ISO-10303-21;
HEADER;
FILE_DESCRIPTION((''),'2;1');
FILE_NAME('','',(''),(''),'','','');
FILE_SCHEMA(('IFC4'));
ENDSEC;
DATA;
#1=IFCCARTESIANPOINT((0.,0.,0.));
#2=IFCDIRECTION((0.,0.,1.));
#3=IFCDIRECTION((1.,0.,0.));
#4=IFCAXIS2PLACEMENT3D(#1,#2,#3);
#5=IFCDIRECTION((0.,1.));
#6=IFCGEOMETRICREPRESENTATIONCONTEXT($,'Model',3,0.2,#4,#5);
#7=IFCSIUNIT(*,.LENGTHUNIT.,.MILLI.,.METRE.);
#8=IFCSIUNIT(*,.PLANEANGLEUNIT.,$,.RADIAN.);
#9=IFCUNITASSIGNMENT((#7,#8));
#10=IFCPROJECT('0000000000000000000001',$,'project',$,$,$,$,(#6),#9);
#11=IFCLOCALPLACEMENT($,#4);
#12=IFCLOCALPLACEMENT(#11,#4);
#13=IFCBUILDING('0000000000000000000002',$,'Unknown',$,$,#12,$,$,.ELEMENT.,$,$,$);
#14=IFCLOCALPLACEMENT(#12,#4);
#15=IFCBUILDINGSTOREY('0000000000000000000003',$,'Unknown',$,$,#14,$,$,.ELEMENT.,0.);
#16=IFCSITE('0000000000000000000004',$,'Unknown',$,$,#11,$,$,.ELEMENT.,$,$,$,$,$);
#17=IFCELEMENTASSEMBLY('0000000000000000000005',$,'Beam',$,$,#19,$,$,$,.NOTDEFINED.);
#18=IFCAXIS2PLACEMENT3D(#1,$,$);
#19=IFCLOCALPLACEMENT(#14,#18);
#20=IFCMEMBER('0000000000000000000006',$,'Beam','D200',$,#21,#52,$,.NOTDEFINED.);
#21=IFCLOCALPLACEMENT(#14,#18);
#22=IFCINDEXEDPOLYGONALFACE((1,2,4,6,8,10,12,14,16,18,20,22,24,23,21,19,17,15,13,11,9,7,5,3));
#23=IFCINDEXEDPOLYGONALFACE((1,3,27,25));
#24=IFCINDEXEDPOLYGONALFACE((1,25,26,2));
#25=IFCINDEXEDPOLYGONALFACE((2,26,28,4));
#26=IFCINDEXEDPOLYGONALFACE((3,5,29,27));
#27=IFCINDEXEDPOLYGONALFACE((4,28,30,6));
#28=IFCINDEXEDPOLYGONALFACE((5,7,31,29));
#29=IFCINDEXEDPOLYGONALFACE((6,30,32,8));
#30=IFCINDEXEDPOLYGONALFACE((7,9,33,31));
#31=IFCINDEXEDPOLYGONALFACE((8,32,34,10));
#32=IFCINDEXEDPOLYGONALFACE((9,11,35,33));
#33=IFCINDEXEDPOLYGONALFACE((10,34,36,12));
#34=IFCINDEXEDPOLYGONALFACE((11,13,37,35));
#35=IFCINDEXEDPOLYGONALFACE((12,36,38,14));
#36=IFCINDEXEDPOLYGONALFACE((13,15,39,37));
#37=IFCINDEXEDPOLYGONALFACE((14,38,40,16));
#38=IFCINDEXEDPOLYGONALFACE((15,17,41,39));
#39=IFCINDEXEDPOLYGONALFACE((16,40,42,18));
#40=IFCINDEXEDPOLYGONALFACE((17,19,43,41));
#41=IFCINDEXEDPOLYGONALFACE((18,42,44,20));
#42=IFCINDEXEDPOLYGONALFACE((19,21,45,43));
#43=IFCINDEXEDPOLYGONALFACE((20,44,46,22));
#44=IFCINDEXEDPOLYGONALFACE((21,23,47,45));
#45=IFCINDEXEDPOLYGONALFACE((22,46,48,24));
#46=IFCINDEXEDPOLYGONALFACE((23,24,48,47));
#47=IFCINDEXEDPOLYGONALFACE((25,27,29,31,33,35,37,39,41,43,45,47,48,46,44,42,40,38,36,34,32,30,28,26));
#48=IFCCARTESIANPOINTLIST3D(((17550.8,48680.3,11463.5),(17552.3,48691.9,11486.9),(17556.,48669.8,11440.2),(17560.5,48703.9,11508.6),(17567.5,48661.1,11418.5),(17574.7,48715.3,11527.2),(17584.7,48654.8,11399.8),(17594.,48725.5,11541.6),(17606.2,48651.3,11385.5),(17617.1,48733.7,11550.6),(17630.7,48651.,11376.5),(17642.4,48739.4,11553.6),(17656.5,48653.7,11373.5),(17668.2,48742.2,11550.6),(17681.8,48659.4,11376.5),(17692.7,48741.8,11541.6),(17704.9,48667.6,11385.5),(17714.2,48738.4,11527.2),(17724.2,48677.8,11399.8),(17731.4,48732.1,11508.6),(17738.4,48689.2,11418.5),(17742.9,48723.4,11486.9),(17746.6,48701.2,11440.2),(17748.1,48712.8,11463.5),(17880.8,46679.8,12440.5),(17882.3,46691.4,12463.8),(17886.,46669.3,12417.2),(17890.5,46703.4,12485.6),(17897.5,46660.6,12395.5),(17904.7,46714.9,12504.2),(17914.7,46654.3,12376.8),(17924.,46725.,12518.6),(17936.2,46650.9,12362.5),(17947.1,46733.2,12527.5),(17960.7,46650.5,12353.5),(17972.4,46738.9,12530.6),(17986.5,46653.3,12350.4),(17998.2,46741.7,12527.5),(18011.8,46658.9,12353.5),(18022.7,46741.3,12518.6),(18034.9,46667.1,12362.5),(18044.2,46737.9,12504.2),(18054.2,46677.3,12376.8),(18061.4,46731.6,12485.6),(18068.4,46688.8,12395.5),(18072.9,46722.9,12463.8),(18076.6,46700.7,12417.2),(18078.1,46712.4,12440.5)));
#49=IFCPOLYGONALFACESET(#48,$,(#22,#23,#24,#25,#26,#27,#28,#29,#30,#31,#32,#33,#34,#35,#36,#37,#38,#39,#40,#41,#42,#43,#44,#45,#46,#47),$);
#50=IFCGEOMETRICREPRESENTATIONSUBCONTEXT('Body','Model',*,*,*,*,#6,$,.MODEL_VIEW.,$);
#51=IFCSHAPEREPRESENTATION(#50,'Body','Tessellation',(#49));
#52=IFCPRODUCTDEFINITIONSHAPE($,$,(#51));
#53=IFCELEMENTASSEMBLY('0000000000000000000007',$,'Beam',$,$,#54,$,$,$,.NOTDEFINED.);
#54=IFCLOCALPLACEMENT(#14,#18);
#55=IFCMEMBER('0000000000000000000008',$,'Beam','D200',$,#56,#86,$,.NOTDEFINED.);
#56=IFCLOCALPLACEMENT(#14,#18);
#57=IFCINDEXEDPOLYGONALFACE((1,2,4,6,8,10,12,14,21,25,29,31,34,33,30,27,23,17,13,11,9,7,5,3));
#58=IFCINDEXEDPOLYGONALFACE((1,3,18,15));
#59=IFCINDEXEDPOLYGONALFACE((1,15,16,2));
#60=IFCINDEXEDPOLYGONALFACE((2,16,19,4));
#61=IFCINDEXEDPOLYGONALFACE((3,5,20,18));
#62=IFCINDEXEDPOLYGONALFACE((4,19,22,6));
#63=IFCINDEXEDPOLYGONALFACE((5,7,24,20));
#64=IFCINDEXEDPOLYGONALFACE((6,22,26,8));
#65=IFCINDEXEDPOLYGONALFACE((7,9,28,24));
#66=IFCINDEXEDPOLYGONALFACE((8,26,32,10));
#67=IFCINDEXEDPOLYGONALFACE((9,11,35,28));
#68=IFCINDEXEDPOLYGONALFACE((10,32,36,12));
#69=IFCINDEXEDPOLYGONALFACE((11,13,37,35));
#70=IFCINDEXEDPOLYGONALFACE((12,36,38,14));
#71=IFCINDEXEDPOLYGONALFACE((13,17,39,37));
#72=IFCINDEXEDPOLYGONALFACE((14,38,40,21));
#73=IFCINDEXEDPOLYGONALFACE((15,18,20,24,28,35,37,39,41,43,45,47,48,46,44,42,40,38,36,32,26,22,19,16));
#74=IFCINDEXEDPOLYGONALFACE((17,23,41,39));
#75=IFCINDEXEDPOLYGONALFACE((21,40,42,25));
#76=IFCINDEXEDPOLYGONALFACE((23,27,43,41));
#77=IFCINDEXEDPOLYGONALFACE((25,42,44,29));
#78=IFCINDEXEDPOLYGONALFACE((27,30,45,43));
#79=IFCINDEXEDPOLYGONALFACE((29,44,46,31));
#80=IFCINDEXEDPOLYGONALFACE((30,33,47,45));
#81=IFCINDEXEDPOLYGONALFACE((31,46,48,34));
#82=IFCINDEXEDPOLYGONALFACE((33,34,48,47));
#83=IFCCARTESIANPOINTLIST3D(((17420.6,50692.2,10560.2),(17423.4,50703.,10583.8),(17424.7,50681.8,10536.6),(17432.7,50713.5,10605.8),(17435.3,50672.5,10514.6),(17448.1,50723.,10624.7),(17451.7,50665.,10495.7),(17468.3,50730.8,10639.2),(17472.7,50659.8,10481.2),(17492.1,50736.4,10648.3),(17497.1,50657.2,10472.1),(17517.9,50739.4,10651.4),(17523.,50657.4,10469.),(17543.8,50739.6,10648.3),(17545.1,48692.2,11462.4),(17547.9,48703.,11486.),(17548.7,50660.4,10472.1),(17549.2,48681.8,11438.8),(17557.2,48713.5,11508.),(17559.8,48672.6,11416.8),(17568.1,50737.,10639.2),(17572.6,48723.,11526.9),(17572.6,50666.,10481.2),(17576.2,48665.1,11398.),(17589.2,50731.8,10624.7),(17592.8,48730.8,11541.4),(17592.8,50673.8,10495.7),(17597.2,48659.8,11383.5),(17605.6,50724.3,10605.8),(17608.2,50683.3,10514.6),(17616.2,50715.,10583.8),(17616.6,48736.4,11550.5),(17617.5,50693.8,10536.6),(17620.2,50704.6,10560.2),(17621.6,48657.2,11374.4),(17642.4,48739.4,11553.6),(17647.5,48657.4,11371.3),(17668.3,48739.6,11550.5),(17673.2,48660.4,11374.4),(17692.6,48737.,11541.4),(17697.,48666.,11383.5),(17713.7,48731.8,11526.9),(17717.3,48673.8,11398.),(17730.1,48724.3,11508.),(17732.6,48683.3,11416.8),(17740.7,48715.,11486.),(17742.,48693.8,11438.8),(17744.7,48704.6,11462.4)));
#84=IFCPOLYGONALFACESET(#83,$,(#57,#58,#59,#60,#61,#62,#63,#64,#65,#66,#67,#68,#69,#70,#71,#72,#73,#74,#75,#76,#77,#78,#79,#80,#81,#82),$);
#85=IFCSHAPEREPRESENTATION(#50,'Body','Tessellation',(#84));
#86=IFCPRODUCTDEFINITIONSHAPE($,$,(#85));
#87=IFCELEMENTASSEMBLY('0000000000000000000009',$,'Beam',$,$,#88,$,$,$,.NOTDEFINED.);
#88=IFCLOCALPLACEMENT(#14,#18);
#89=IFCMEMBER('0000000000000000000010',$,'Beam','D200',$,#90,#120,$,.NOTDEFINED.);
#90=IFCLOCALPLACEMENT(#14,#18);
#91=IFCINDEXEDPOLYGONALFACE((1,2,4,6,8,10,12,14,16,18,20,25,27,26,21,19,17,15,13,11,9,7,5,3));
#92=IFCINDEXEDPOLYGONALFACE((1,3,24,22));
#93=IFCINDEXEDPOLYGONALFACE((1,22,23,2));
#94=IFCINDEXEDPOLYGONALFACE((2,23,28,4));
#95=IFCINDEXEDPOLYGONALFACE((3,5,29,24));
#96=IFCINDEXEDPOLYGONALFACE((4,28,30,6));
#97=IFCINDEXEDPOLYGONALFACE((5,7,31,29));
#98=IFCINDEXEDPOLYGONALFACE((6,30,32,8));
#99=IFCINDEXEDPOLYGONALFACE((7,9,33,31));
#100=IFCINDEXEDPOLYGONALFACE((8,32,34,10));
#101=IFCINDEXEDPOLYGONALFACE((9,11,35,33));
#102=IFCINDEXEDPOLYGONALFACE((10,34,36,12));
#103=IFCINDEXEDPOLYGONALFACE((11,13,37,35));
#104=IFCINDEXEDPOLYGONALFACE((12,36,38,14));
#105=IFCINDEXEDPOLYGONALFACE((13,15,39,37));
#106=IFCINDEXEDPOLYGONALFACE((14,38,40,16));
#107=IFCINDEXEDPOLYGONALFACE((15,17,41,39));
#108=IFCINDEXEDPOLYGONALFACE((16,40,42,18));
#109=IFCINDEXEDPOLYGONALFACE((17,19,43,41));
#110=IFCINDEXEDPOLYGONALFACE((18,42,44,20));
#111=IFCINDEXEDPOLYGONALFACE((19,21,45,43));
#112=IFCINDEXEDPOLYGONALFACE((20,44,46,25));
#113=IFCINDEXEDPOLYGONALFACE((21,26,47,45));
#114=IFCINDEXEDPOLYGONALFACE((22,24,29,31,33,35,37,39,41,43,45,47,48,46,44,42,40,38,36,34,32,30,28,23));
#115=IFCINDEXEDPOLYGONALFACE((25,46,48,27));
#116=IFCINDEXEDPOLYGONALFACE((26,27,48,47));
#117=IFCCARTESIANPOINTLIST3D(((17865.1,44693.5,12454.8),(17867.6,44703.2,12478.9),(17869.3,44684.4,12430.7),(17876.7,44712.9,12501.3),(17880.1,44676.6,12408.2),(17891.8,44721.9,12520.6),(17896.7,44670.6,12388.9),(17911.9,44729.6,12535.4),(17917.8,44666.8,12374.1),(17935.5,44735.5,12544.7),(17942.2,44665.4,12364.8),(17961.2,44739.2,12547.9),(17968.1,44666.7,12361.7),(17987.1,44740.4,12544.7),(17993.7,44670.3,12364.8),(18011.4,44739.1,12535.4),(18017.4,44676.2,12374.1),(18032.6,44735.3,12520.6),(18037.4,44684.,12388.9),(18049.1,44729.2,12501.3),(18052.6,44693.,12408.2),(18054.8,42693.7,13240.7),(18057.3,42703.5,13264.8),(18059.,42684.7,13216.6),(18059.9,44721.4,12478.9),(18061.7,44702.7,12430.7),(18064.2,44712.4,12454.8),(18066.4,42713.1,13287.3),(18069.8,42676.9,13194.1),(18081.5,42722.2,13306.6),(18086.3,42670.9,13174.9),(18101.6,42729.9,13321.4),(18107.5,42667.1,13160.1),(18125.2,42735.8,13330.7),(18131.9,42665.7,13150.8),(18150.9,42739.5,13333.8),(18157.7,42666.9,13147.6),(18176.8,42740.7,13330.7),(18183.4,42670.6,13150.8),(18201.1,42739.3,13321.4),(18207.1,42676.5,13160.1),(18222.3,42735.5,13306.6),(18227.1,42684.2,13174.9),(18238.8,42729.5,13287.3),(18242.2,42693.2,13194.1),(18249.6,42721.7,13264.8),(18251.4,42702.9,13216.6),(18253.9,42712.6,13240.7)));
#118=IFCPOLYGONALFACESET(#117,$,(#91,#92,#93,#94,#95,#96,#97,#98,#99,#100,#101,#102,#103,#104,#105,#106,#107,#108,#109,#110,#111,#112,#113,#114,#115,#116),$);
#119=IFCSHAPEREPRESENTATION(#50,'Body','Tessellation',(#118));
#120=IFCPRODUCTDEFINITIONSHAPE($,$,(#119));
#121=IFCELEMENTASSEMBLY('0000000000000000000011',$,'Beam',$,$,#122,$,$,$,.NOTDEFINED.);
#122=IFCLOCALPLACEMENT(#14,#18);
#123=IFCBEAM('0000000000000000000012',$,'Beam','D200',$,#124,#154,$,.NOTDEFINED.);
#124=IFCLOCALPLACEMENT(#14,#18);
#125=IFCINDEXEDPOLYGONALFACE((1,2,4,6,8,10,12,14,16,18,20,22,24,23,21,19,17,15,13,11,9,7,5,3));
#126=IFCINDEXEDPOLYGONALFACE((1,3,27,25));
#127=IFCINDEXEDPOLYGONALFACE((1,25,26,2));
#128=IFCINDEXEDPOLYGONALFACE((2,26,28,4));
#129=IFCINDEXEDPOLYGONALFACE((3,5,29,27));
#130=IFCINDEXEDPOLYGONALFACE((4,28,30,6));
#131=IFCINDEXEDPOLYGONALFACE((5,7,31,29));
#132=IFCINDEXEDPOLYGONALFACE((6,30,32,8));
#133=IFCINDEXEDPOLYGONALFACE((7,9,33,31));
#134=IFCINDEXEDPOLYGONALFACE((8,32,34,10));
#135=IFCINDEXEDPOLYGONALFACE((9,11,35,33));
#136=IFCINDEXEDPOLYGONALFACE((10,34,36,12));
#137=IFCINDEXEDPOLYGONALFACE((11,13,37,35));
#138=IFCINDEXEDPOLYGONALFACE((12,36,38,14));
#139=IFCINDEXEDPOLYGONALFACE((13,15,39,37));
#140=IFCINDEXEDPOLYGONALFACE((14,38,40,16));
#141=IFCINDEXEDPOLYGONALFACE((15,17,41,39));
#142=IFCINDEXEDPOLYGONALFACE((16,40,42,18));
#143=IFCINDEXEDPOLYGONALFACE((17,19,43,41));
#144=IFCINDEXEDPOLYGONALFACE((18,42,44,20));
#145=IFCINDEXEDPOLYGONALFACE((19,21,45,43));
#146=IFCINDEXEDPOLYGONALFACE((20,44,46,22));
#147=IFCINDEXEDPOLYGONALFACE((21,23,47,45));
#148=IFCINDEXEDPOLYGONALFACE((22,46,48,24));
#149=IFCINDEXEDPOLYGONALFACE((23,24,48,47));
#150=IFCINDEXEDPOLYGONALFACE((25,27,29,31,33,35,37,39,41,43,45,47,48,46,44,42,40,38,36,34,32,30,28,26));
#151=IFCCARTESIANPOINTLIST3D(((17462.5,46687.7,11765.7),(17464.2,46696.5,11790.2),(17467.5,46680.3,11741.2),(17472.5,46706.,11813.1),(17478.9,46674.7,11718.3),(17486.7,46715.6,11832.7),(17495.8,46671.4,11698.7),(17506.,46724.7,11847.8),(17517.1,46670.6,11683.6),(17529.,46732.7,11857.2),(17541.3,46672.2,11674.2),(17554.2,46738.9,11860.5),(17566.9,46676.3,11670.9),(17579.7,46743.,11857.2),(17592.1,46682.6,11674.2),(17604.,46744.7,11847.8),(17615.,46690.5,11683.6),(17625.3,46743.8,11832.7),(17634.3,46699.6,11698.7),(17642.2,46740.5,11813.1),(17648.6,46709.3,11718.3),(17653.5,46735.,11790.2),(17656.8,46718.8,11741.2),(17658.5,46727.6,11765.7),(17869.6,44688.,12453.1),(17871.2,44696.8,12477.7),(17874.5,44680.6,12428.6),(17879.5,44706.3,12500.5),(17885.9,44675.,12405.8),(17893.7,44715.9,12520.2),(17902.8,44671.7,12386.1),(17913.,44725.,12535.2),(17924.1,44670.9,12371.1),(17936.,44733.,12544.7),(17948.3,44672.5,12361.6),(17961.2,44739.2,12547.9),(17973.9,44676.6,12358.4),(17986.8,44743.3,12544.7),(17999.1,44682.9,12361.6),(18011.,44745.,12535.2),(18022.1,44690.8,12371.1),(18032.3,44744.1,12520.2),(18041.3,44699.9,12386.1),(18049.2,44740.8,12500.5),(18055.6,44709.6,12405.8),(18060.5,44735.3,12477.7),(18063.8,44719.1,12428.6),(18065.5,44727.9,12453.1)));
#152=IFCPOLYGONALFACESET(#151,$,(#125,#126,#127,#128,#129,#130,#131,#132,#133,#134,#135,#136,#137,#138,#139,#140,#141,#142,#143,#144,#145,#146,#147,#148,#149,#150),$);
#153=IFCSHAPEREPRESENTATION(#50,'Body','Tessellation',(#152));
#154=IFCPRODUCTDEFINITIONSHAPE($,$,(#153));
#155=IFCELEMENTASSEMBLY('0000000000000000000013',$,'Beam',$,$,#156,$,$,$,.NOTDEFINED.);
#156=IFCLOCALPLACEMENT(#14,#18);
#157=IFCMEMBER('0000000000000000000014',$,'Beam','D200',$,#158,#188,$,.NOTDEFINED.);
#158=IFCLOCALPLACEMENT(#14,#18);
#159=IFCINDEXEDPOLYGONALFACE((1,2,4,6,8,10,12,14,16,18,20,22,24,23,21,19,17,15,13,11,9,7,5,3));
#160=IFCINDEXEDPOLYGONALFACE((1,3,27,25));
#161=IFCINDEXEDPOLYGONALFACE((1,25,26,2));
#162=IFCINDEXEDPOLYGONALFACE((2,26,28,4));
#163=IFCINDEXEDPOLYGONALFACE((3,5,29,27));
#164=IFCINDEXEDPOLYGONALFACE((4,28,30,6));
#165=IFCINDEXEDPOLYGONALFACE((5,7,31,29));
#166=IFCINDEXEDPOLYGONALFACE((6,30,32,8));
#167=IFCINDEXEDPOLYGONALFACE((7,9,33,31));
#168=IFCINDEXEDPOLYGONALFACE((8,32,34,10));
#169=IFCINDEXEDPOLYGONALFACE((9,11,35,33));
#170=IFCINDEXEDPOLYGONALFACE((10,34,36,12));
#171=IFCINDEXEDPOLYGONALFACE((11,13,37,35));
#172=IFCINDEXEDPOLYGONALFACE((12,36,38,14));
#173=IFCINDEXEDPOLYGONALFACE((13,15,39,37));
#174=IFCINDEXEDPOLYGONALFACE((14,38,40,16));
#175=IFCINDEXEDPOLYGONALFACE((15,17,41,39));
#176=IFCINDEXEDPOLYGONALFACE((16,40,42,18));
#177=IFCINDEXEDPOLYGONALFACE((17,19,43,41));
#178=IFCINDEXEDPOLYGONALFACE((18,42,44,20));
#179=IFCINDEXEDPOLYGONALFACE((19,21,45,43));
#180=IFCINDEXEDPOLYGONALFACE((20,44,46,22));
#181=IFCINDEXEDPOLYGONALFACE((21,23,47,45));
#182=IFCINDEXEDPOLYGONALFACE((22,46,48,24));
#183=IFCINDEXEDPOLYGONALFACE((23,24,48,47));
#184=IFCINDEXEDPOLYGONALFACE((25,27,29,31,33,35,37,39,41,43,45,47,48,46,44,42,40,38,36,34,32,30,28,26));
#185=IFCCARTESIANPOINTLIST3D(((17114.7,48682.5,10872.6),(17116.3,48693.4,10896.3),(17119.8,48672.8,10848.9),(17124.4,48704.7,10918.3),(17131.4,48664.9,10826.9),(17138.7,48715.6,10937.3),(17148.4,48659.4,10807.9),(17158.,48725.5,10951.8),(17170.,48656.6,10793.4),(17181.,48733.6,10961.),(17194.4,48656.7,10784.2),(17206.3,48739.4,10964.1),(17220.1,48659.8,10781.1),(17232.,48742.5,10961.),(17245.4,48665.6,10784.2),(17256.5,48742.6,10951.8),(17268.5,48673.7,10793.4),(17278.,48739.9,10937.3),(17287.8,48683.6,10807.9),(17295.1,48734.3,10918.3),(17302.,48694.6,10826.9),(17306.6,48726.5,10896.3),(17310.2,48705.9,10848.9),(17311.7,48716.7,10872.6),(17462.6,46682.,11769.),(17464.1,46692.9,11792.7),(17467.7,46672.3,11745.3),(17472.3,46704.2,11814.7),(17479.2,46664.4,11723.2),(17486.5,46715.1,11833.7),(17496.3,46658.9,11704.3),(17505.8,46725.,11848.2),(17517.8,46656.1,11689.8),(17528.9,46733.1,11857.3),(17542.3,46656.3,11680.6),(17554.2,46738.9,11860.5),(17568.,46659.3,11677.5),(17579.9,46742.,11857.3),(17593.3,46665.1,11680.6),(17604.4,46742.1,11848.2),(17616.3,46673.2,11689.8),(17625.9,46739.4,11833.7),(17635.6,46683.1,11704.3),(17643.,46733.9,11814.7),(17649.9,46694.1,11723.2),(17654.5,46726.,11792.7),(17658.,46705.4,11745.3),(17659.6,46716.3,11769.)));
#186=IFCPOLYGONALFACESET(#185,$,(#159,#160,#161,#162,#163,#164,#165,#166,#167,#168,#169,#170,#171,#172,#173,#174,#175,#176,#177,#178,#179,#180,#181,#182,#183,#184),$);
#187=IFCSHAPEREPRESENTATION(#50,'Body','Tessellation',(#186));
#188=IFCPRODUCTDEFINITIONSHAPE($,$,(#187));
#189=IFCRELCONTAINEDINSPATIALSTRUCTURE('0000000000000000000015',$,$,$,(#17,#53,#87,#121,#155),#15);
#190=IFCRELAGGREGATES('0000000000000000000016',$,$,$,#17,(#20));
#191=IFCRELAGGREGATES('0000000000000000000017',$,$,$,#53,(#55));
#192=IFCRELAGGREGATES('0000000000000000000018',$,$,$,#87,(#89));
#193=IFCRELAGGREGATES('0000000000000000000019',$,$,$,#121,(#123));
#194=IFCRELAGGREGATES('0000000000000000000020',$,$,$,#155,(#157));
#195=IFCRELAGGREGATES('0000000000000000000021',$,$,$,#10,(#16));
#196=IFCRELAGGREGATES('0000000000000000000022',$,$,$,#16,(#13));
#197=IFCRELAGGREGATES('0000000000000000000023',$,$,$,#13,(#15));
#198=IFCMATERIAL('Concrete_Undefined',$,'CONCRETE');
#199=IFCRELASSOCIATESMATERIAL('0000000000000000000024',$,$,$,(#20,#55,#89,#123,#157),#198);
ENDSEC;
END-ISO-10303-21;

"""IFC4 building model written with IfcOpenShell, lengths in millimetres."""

from ifc_helpers import new_model, si_unit, direction, frame, origin_with_axes, place, context, subcontext, project, spatial, line, indexed_curve, outline, extrude, material, element, aggregate, save


model = new_model("IFC4")

# Units and contexts
model_context = context("Model", 3, precision=0.2, world=origin_with_axes(), true_north=direction((0.0, 1.0)))
body_context = subcontext(model_context, "Body", "Model", "MODEL_VIEW")
ifc_project = project(units=[si_unit("LENGTHUNIT", "METRE", prefix="MILLI"), si_unit("PLANEANGLEUNIT", "RADIAN")], contexts=[model_context])

# Site, building, storey
site_placement = place(None, origin_with_axes())
site = spatial("IfcSite", under=ifc_project, at=site_placement, Name="Unknown", CompositionType="ELEMENT")
building_placement = place(site_placement, origin_with_axes())
building = spatial("IfcBuilding", under=site, at=building_placement, Name="Unknown", CompositionType="ELEMENT")
storey_placement = place(building_placement, origin_with_axes())
storey = spatial("IfcBuildingStorey", under=building, at=storey_placement, Name="Unknown", CompositionType="ELEMENT", Elevation=0.0)

# Shared definitions
ifc_material = material(Name="Concrete_Undefined", Category="CONCRETE")

# Element assemblies, members
assembly_1_placement = place(storey_placement, frame((17649.4, 48696.6, 11463.5), z_axis=(-0.986666, -0.162758, 0.0), x_axis=(0.146624, -0.888853, 0.434098)))
assembly_1 = element("IfcElementAssembly", 1, at=assembly_1_placement, inside=storey, Name="Beam", PredefinedType="NOTDEFINED")
member_1_placement = place(assembly_1_placement, origin_with_axes())
member_1 = element("IfcMember", 2, at=member_1_placement, material=ifc_material, Name="Beam", Description="D200", PredefinedType="NOTDEFINED", context=body_context, shape_type="SolidModel", body=[
    extrude(outline(indexed_curve([(100.0, 0.0), (96.6, 25.9), (86.6, 50.0), (70.7, 70.7), (50.0, 86.6), (25.9, 96.6), (0.0, 100.0), (-25.9, 96.6), (-50.0, 86.6), (-70.7, 70.7), (-86.6, 50.0), (-96.6, 25.9), (-100.0, 0.0), (-96.6, -25.9), (-86.6, -50.0), (-70.7, -70.7), (-50.0, -86.6), (-25.9, -96.6), (0.0, -100.0), (25.9, -96.6), (50.0, -86.6), (70.7, -70.7), (86.6, -50.0), (96.6, -25.9)], segments=[line(1, 2, 3, 4, 5, 6, 7, 8, 9, 10, 11, 12, 13, 14, 15, 16, 17, 18, 19, 20, 21, 22, 23, 24, 1)])), frame((0.0, 0.0, 0.0), z_axis=(-1.0, 0.0, 0.0), x_axis=(0.0, 0.0, 1.0)), (0.0, 0.0, -1.0), 2250.6),
])
aggregate(assembly_1, [member_1])
assembly_2_placement = place(storey_placement, frame((17520.4, 50698.4, 10560.2), z_axis=(-0.998068, -0.062127, 0.0), x_axis=(0.05665, -0.91007, 0.410564)))
assembly_2 = element("IfcElementAssembly", 3, at=assembly_2_placement, inside=storey, Name="Beam", PredefinedType="NOTDEFINED")
member_2_placement = place(assembly_2_placement, origin_with_axes())
member_2 = element("IfcMember", 4, at=member_2_placement, material=ifc_material, Name="Beam", Description="D200", PredefinedType="NOTDEFINED", context=body_context, shape_type="SolidModel", body=[
    extrude(outline(indexed_curve([(100.0, 0.0), (96.6, 25.9), (86.6, 50.0), (70.7, 70.7), (50.0, 86.6), (25.9, 96.6), (0.0, 100.0), (-25.9, 96.6), (-50.0, 86.6), (-70.7, 70.7), (-86.6, 50.0), (-96.6, 25.9), (-100.0, 0.0), (-96.6, -25.9), (-86.6, -50.0), (-70.7, -70.7), (-50.0, -86.6), (-25.9, -96.6), (0.0, -100.0), (25.9, -96.6), (50.0, -86.6), (70.7, -70.7), (86.6, -50.0), (96.6, -25.9)], segments=[line(1, 2, 3, 4, 5, 6, 7, 8, 9, 10, 11, 12, 13, 14, 15, 16, 17, 18, 19, 20, 21, 22, 23, 24, 1)])), frame((0.0, 0.0, 0.0), z_axis=(-1.0, 0.0, 0.0), x_axis=(0.0, 0.0, 1.0)), (0.0, 0.0, -1.0), 2197.6),
])
aggregate(assembly_2, [member_2])
assembly_3_placement = place(storey_placement, frame((17964.6, 44702.9, 12454.8), z_axis=(-0.995531, -0.094435, 0.0), x_axis=(0.087944, -0.927097, 0.364358)))
assembly_3 = element("IfcElementAssembly", 5, at=assembly_3_placement, inside=storey, Name="Beam", PredefinedType="NOTDEFINED")
member_3_placement = place(assembly_3_placement, origin_with_axes())
member_3 = element("IfcMember", 6, at=member_3_placement, material=ifc_material, Name="Beam", Description="D200", PredefinedType="NOTDEFINED", context=body_context, shape_type="SolidModel", body=[
    extrude(outline(indexed_curve([(100.0, 0.0), (96.6, 25.9), (86.6, 50.0), (70.7, 70.7), (50.0, 86.6), (25.9, 96.6), (0.0, 100.0), (-25.9, 96.6), (-50.0, 86.6), (-70.7, 70.7), (-86.6, 50.0), (-96.6, 25.9), (-100.0, 0.0), (-96.6, -25.9), (-86.6, -50.0), (-70.7, -70.7), (-50.0, -86.6), (-25.9, -96.6), (0.0, -100.0), (25.9, -96.6), (50.0, -86.6), (70.7, -70.7), (86.6, -50.0), (96.6, -25.9)], segments=[line(1, 2, 3, 4, 5, 6, 7, 8, 9, 10, 11, 12, 13, 14, 15, 16, 17, 18, 19, 20, 21, 22, 23, 24, 1)])), frame((0.0, 0.0, 0.0), z_axis=(-1.0, 0.0, 0.0), x_axis=(0.0, 0.0, 1.0)), (0.0, 0.0, -1.0), 2157.0),
])
aggregate(assembly_3, [member_3])

# Element assembly, beam
assembly_4_placement = place(storey_placement, frame((17560.5, 46707.6, 11765.7), z_axis=(-0.97991, -0.199443, 0.0), x_axis=(0.189006, -0.928634, 0.319242)))
assembly_4 = element("IfcElementAssembly", 7, at=assembly_4_placement, inside=storey, Name="Beam", PredefinedType="NOTDEFINED")
beam_1_placement = place(assembly_4_placement, origin_with_axes())
beam_1 = element("IfcBeam", 8, at=beam_1_placement, material=ifc_material, Name="Beam", Description="D200", PredefinedType="NOTDEFINED", context=body_context, shape_type="SolidModel", body=[
    extrude(outline(indexed_curve([(100.0, 0.0), (96.6, 25.9), (86.6, 50.0), (70.7, 70.7), (50.0, 86.6), (25.9, 96.6), (0.0, 100.0), (-25.9, 96.6), (-50.0, 86.6), (-70.7, 70.7), (-86.6, 50.0), (-96.6, 25.9), (-100.0, 0.0), (-96.6, -25.9), (-86.6, -50.0), (-70.7, -70.7), (-50.0, -86.6), (-25.9, -96.6), (0.0, -100.0), (25.9, -96.6), (50.0, -86.6), (70.7, -70.7), (86.6, -50.0), (96.6, -25.9)], segments=[line(1, 2, 3, 4, 5, 6, 7, 8, 9, 10, 11, 12, 13, 14, 15, 16, 17, 18, 19, 20, 21, 22, 23, 24, 1)])), frame((0.0, 0.0, 0.0), z_axis=(-1.0, 0.0, 0.0), x_axis=(0.0, 0.0, 1.0)), (0.0, 0.0, -1.0), 2153.4),
])
aggregate(assembly_4, [beam_1])

# Element assembly, member
assembly_5_placement = place(storey_placement, frame((17213.2, 48699.6, 10872.6), z_axis=(-0.985215, -0.171322, 0.0), x_axis=(0.156729, -0.901299, 0.40385)))
assembly_5 = element("IfcElementAssembly", 9, at=assembly_5_placement, inside=storey, Name="Beam", PredefinedType="NOTDEFINED")
member_4_placement = place(assembly_5_placement, origin_with_axes())
member_4 = element("IfcMember", 10, at=member_4_placement, material=ifc_material, Name="Beam", Description="D200", PredefinedType="NOTDEFINED", context=body_context, shape_type="SolidModel", body=[
    extrude(outline(indexed_curve([(100.0, 0.0), (96.6, 25.9), (86.6, 50.0), (70.7, 70.7), (50.0, 86.6), (25.9, 96.6), (0.0, 100.0), (-25.9, 96.6), (-50.0, 86.6), (-70.7, 70.7), (-86.6, 50.0), (-96.6, 25.9), (-100.0, 0.0), (-96.6, -25.9), (-86.6, -50.0), (-70.7, -70.7), (-50.0, -86.6), (-25.9, -96.6), (0.0, -100.0), (25.9, -96.6), (50.0, -86.6), (70.7, -70.7), (86.6, -50.0), (96.6, -25.9)], segments=[line(1, 2, 3, 4, 5, 6, 7, 8, 9, 10, 11, 12, 13, 14, 15, 16, 17, 18, 19, 20, 21, 22, 23, 24, 1)])), frame((0.0, 0.0, 0.0), z_axis=(-1.0, 0.0, 0.0), x_axis=(0.0, 0.0, 1.0)), (0.0, 0.0, -1.0), 2219.6),
])
aggregate(assembly_5, [member_4])

save(model, "model.ifc")
